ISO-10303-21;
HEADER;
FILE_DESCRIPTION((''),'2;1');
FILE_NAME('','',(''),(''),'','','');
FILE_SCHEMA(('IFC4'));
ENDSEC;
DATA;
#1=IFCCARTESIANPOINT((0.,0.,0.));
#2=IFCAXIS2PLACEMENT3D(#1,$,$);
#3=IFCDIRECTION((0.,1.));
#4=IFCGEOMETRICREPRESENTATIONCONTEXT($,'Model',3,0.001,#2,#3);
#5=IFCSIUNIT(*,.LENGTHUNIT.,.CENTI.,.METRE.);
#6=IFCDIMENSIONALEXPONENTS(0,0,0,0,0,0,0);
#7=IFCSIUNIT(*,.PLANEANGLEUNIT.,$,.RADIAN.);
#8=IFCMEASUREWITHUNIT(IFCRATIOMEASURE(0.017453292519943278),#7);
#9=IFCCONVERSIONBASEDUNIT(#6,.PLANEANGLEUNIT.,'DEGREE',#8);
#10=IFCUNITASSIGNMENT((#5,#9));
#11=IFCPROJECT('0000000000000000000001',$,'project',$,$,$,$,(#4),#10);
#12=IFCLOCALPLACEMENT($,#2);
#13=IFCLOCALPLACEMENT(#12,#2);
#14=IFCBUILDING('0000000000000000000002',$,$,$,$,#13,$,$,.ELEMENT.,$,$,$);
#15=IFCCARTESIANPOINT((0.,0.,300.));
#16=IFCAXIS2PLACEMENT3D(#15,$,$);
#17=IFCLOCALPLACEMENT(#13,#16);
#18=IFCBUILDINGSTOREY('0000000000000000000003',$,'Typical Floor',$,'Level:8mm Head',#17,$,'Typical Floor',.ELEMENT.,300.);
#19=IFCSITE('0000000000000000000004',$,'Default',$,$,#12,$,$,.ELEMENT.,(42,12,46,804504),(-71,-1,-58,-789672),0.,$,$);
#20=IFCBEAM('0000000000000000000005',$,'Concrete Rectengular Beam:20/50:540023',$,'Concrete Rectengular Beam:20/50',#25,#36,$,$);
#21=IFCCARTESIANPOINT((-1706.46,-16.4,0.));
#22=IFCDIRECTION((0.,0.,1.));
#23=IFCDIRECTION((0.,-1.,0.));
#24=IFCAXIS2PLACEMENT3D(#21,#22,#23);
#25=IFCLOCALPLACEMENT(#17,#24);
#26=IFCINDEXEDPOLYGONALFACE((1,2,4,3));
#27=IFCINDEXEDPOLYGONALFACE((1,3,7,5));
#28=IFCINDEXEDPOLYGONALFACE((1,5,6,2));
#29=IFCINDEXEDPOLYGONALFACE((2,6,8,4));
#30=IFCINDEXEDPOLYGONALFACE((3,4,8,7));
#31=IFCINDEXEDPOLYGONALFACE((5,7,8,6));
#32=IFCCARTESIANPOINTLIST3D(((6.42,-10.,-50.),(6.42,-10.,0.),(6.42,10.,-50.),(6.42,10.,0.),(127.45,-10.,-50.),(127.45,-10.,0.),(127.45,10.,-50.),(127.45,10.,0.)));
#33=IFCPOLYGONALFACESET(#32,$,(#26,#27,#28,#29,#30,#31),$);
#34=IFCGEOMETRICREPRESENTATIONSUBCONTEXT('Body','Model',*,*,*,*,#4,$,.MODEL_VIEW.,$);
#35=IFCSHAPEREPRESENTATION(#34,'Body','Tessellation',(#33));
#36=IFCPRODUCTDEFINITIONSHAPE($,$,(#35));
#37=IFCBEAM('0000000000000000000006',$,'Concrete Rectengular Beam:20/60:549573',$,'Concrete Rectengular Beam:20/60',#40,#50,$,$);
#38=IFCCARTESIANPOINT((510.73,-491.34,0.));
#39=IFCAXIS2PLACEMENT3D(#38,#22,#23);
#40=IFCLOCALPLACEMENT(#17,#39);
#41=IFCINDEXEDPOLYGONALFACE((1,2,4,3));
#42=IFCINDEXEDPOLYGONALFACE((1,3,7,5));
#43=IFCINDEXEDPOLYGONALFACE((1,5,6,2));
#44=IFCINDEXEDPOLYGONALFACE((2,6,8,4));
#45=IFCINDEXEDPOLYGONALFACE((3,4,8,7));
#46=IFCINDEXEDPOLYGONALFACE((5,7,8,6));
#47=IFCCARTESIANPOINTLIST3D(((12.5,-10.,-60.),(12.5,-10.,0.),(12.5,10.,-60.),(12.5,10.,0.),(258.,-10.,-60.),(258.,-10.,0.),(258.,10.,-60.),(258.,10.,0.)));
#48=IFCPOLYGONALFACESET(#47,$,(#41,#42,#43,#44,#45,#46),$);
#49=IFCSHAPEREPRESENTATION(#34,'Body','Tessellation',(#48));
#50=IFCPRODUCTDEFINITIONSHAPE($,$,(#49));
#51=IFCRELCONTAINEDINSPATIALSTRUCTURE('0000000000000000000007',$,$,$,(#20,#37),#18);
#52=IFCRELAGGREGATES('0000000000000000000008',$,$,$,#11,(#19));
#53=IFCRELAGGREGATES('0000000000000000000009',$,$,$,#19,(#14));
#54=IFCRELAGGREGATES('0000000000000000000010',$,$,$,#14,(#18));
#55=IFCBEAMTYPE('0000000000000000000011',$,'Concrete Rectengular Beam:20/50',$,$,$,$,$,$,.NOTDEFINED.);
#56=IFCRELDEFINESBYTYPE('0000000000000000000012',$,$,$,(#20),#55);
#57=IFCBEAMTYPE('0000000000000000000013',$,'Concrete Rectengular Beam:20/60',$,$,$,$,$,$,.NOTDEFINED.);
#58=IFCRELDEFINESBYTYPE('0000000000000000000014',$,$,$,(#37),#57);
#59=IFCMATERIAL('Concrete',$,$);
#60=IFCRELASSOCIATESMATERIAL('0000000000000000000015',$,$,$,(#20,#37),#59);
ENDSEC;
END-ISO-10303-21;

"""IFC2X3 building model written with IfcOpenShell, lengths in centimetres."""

from ifc_helpers import new_model, entity, si_unit, converted_unit, direction, frame, frame_2d, origin, place, context, subcontext, project, spatial, rectangle, extrude, material, type_object, element, save


model = new_model("IFC2X3")

# Units and contexts
model_context = context("Model", 3, precision=0.001, world=origin(), true_north=direction((0.0, 1.0)))
body_context = subcontext(model_context, "Body", "Model", "MODEL_VIEW")
ifc_project = project(units=[si_unit("LENGTHUNIT", "METRE", prefix="CENTI"), converted_unit("PLANEANGLEUNIT", "DEGREE", entity("IfcRatioMeasure", 0.017453292519943278), si_unit("PLANEANGLEUNIT", "RADIAN"), dimensions=[0, 0, 0, 0, 0, 0, 0])], contexts=[model_context])

# Site, building, storey
site_placement = place(None, origin())
site = spatial("IfcSite", under=ifc_project, at=site_placement, Name="Default", CompositionType="ELEMENT", RefLatitude=(42, 12, 46, 804504), RefLongitude=(-71, -1, -58, -789672), RefElevation=0.0)
building_placement = place(site_placement, origin())
building = spatial("IfcBuilding", under=site, at=building_placement, CompositionType="ELEMENT")
storey_placement = place(building_placement, frame((0.0, 0.0, 300.0)))
storey = spatial("IfcBuildingStorey", under=building, at=storey_placement, Name="Typical Floor", ObjectType="Level:8mm Head", LongName="Typical Floor", CompositionType="ELEMENT", Elevation=300.0)

# Beams
ifc_material = material(Name="Concrete")
beam_type_1 = type_object("IfcBeamType", Name="Concrete Rectengular Beam:20/50", PredefinedType="NOTDEFINED")
beam_1_placement = place(storey_placement, frame((-1706.46, -16.4, 0.0), z_axis=(0.0, 0.0, 1.0), x_axis=(0.0, -1.0, 0.0)))
element("IfcBeam", 1, at=beam_1_placement, inside=storey, type_object=beam_type_1, material=ifc_material, Name="Concrete Rectengular Beam:20/50:540023", ObjectType="Concrete Rectengular Beam:20/50", context=body_context, shape_type="SweptSolid", body=[
    extrude(rectangle(XDim=50.0, YDim=20.0, at=frame_2d((0.0, 0.0), x_axis=(1.0, 0.0))), frame((6.42, 0.0, -25.0), z_axis=(1.0, 0.0, 0.0), x_axis=(0.0, 0.0, -1.0)), (0.0, 0.0, 1.0), 121.02),
])
beam_type_2 = type_object("IfcBeamType", Name="Concrete Rectengular Beam:20/60", PredefinedType="NOTDEFINED")
beam_2_placement = place(storey_placement, frame((510.73, -491.34, 0.0), z_axis=(0.0, 0.0, 1.0), x_axis=(0.0, -1.0, 0.0)))
element("IfcBeam", 2, at=beam_2_placement, inside=storey, type_object=beam_type_2, material=ifc_material, Name="Concrete Rectengular Beam:20/60:549573", ObjectType="Concrete Rectengular Beam:20/60", context=body_context, shape_type="SweptSolid", body=[
    extrude(rectangle(XDim=60.0, YDim=20.0, at=frame_2d((0.0, 0.0), x_axis=(1.0, 0.0))), frame((12.5, 0.0, -30.0), z_axis=(1.0, 0.0, 0.0), x_axis=(0.0, 0.0, -1.0)), (0.0, 0.0, 1.0), 245.5),
])

save(model, "model.ifc")
